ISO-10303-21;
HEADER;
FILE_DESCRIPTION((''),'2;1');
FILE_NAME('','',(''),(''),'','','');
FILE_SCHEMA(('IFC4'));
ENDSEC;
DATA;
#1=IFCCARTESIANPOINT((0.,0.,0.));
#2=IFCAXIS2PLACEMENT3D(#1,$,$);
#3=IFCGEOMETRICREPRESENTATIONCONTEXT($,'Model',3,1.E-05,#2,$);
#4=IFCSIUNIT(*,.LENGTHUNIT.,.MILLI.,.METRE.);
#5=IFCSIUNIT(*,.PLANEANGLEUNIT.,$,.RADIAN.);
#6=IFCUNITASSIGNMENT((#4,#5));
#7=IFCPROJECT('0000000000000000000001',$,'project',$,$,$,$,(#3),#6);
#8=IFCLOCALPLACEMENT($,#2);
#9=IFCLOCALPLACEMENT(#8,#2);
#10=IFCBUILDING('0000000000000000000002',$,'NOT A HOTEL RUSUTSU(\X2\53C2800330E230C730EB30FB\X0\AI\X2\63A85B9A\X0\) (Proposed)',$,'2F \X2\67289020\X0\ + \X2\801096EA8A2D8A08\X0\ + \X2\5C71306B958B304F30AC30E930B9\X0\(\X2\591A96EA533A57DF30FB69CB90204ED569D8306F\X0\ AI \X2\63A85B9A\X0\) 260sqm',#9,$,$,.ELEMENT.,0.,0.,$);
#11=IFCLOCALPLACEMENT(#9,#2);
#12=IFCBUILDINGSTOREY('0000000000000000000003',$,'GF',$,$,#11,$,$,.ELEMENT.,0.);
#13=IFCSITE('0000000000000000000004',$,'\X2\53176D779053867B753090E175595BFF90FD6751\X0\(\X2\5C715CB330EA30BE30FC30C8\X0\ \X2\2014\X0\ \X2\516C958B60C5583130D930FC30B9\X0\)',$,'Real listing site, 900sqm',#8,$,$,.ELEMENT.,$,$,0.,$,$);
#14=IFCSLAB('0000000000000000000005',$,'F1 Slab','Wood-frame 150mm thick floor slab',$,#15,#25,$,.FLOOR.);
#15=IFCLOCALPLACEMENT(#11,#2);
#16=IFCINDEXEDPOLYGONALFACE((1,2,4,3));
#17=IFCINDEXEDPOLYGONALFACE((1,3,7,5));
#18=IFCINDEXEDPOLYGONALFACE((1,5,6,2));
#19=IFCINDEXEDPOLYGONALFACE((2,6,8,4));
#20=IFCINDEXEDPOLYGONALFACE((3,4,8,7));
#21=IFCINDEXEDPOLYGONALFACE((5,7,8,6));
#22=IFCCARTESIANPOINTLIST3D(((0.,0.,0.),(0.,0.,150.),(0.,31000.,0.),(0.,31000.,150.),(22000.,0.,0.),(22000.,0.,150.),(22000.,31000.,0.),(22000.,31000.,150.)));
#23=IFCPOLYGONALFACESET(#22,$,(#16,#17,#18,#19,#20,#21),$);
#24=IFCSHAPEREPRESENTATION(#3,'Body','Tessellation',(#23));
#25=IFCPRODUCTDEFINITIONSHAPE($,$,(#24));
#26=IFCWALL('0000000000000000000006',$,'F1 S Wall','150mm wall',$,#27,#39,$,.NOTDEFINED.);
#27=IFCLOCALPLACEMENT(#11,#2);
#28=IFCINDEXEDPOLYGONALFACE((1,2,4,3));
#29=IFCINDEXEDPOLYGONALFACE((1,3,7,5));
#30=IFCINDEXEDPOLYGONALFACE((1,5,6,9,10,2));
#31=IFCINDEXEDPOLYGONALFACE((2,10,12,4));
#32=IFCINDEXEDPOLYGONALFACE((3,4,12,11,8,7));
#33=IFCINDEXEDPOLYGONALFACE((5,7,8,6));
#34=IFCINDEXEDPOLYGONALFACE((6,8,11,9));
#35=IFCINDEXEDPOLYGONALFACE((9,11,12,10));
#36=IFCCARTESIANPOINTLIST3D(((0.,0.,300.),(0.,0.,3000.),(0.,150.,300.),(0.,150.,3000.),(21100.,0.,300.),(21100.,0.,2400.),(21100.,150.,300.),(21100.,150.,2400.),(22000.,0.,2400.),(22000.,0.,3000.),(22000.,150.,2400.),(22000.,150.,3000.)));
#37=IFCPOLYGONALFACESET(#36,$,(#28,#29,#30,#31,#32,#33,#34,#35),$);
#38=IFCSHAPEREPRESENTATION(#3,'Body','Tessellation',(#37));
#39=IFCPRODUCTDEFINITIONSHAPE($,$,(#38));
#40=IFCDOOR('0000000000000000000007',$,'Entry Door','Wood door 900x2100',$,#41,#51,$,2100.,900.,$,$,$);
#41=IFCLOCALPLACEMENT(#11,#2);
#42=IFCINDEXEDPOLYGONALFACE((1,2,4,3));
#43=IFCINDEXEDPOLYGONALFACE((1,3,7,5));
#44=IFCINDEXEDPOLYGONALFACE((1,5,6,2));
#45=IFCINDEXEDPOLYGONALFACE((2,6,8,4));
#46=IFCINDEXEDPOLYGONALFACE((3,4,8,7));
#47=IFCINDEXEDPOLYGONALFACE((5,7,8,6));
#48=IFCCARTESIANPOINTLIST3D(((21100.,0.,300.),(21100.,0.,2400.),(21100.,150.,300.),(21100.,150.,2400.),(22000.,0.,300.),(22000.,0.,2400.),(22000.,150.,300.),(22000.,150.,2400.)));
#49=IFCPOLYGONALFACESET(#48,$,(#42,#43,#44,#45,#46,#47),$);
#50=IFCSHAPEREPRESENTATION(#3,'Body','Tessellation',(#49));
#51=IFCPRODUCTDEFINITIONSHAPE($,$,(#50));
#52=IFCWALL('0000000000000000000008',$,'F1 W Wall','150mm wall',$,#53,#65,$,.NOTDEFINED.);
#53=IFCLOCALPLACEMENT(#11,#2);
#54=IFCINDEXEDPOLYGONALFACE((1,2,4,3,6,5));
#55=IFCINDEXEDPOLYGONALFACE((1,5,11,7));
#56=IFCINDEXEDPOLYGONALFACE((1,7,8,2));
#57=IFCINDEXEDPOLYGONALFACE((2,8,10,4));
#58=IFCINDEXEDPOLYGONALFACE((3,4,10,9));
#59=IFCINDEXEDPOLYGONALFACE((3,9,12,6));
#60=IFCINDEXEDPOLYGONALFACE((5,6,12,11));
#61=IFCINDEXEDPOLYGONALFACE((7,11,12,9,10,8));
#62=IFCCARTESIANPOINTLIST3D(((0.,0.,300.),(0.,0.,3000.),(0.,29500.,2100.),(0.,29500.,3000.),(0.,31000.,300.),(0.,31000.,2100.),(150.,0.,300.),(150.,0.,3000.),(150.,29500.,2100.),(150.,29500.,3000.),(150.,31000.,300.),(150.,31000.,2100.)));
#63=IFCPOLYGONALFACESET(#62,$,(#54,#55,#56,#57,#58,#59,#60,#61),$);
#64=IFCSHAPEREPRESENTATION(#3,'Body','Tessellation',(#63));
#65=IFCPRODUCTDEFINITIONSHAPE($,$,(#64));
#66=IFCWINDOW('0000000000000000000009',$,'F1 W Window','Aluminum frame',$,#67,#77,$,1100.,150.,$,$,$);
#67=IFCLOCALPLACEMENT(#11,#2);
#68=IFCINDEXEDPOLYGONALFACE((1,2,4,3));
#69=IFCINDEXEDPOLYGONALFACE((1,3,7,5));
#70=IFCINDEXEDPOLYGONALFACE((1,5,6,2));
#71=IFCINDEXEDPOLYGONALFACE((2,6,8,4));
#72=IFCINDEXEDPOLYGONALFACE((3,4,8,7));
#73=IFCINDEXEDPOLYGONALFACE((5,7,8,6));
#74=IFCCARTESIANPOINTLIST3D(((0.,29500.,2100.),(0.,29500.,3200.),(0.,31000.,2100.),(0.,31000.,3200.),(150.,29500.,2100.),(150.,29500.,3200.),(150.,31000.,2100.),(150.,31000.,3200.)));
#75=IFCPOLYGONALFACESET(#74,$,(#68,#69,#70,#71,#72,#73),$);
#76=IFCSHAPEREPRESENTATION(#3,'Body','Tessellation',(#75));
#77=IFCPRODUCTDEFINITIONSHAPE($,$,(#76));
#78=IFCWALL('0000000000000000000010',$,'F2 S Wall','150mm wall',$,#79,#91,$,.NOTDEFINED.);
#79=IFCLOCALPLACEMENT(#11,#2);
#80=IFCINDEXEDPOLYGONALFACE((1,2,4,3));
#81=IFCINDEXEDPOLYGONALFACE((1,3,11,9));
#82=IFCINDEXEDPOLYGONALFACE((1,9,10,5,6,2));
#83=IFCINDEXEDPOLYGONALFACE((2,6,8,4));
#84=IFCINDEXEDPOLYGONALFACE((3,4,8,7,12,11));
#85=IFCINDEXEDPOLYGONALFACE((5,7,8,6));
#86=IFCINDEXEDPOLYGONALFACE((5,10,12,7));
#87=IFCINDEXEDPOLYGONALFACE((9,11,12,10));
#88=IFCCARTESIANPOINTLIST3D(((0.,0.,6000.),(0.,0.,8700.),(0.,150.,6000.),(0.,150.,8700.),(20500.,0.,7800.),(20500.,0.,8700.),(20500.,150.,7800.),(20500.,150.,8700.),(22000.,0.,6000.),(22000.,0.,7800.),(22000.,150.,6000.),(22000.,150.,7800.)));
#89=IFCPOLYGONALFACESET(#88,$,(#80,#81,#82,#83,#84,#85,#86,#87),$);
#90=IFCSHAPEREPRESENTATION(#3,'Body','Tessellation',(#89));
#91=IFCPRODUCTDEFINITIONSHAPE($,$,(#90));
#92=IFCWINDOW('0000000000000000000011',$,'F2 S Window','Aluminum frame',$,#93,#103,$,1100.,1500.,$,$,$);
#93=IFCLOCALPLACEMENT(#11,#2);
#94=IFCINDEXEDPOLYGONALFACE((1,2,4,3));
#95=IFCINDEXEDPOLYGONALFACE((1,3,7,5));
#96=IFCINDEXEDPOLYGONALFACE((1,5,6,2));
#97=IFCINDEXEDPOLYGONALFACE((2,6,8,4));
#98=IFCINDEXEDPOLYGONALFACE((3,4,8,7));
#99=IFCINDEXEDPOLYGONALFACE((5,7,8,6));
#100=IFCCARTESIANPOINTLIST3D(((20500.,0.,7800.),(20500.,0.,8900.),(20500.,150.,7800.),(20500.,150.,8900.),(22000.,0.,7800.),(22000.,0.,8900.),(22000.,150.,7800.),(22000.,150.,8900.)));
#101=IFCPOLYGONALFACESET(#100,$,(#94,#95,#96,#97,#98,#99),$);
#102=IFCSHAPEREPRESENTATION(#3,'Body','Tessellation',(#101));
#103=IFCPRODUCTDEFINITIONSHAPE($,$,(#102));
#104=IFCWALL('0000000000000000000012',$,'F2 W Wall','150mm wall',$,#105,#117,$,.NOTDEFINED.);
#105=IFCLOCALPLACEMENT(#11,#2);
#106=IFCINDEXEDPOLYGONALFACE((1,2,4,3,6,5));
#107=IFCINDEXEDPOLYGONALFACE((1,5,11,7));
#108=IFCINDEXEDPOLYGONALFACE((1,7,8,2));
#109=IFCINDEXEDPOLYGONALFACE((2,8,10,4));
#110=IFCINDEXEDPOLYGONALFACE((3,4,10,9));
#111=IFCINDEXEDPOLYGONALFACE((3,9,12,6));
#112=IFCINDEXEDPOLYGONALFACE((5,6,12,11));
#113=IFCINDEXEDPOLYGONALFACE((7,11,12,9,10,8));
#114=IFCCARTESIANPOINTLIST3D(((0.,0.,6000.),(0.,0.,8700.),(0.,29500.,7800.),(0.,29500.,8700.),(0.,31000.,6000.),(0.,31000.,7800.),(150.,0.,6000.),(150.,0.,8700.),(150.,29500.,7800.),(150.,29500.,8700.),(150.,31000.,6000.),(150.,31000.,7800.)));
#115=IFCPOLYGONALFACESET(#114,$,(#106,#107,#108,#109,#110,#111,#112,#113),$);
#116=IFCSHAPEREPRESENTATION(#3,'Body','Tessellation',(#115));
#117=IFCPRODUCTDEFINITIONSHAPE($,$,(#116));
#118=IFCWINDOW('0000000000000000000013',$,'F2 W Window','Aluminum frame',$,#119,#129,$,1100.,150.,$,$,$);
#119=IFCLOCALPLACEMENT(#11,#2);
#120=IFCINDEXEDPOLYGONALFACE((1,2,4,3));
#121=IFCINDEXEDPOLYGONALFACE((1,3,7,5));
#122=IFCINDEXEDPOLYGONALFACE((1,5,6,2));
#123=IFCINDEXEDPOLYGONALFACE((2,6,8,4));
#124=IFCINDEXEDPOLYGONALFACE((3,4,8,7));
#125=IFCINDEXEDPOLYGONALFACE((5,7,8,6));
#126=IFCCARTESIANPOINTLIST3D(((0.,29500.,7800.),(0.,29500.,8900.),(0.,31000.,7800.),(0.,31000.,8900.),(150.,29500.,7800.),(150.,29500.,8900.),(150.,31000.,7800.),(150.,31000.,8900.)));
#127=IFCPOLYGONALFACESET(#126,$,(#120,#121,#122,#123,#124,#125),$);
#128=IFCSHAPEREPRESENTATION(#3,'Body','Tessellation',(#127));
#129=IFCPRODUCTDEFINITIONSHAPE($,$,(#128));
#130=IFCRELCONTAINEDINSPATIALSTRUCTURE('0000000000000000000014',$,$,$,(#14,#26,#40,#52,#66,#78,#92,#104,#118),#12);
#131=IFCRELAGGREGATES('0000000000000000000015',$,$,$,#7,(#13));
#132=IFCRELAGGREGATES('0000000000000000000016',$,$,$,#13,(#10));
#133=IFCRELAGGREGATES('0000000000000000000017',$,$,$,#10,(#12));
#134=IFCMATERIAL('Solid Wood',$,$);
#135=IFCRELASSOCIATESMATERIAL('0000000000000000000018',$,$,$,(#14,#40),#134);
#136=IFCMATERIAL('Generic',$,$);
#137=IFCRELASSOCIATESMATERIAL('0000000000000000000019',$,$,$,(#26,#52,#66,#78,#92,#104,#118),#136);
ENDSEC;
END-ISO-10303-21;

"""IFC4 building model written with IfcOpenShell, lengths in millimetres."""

from ifc_helpers import new_model, si_unit, frame, frame_2d, origin, place, context, project, spatial, rectangle, extrude, material, element, fill, save


model = new_model("IFC4")

# Units and contexts
model_context = context("Model", 3, precision=1e-05, world=origin())
ifc_project = project(units=[si_unit("LENGTHUNIT", "METRE", prefix="MILLI"), si_unit("PLANEANGLEUNIT", "RADIAN")], contexts=[model_context])

# Site, building, storey
site_placement = place(None, origin())
site = spatial("IfcSite", under=ifc_project, at=site_placement, Name="北海道虻田郡留寿都村(山岳リゾート — 公開情報ベース)", ObjectType="Real listing site, 900sqm", CompositionType="ELEMENT", RefElevation=0.0)
building_placement = place(site_placement, origin())
building = spatial("IfcBuilding", under=site, at=building_placement, Name="NOT A HOTEL RUSUTSU(参考モデル・AI推定) (Proposed)", ObjectType="2F 木造 + 耐雪設計 + 山に開くガラス(多雪区域・構造仕様は AI 推定) 260sqm", CompositionType="ELEMENT", ElevationOfRefHeight=0.0, ElevationOfTerrain=0.0)
storey_placement = place(building_placement, origin())
storey = spatial("IfcBuildingStorey", under=building, at=storey_placement, Name="GF", CompositionType="ELEMENT", Elevation=0.0)

# Slab
ifc_material_1 = material(Name="Solid Wood")
slab_1_placement = place(storey_placement, origin())
element("IfcSlab", 1, at=slab_1_placement, inside=storey, material=ifc_material_1, Name="F1 Slab", Description="Wood-frame 150mm thick floor slab", PredefinedType="FLOOR", context=model_context, shape_type="SweptSolid", body=[
    extrude(rectangle(XDim=22000.0, YDim=31000.0, at=frame_2d((11000.0, 15500.0))), origin(), (0.0, 0.0, 1.0), 150.0),
])

# Shared definitions
ifc_material_2 = material(Name="Generic")

# Wall, opening, door
wall_1_placement = place(storey_placement, frame((0.0, 0.0, 150.0)))
wall_1 = element("IfcWall", 2, at=wall_1_placement, inside=storey, material=ifc_material_2, Name="F1 S Wall", Description="150mm wall", PredefinedType="NOTDEFINED", context=model_context, shape_type="SweptSolid", body=[
    extrude(rectangle(XDim=22000.0, YDim=150.0, at=frame_2d((11000.0, 75.0))), frame((0.0, 0.0, 150.0)), (0.0, 0.0, 1.0), 2700.0),
])
opening_1_placement = place(storey_placement, frame((10550.0, 0.0, 150.0)))
opening_1 = element("IfcOpeningElement", 3, at=opening_1_placement, cuts=wall_1, PredefinedType="NOTDEFINED", context=model_context, shape_type="SweptSolid", body=[
    extrude(rectangle(XDim=900.0, YDim=150.0, at=frame_2d((450.0, 75.0))), frame((10550.0, 0.0, 150.0)), (0.0, 0.0, 1.0), 2100.0),
])
door_placement = place(storey_placement, frame((10550.0, 0.0, 150.0)))
door = element("IfcDoor", 4, at=door_placement, inside=storey, material=ifc_material_1, Name="Entry Door", Description="Wood door 900x2100", OverallHeight=2100.0, OverallWidth=900.0, context=model_context, shape_type="SweptSolid", body=[
    extrude(rectangle(XDim=900.0, YDim=150.0, at=frame_2d((450.0, 75.0))), frame((10550.0, 0.0, 150.0)), (0.0, 0.0, 1.0), 2100.0),
])
fill(opening_1, door)

# Walls, openings, windows
wall_2_placement = place(storey_placement, frame((0.0, 0.0, 150.0)))
wall_2 = element("IfcWall", 5, at=wall_2_placement, inside=storey, material=ifc_material_2, Name="F1 W Wall", Description="150mm wall", PredefinedType="NOTDEFINED", context=model_context, shape_type="SweptSolid", body=[
    extrude(rectangle(XDim=150.0, YDim=31000.0, at=frame_2d((75.0, 15500.0))), frame((0.0, 0.0, 150.0)), (0.0, 0.0, 1.0), 2700.0),
])
opening_2_placement = place(storey_placement, frame((0.0, 14750.0, 1050.0)))
opening_2 = element("IfcOpeningElement", 6, at=opening_2_placement, cuts=wall_2, PredefinedType="NOTDEFINED", context=model_context, shape_type="SweptSolid", body=[
    extrude(rectangle(XDim=150.0, YDim=1500.0, at=frame_2d((75.0, 750.0))), frame((0.0, 14750.0, 1050.0)), (0.0, 0.0, 1.0), 1100.0),
])
window_1_placement = place(storey_placement, frame((0.0, 14750.0, 1050.0)))
window_1 = element("IfcWindow", 7, at=window_1_placement, inside=storey, material=ifc_material_2, Name="F1 W Window", Description="Aluminum frame", OverallHeight=1100.0, OverallWidth=150.0, context=model_context, shape_type="SweptSolid", body=[
    extrude(rectangle(XDim=150.0, YDim=1500.0, at=frame_2d((75.0, 750.0))), frame((0.0, 14750.0, 1050.0)), (0.0, 0.0, 1.0), 1100.0),
])
fill(opening_2, window_1)
wall_3_placement = place(storey_placement, frame((0.0, 0.0, 3000.0)))
wall_3 = element("IfcWall", 8, at=wall_3_placement, inside=storey, material=ifc_material_2, Name="F2 S Wall", Description="150mm wall", PredefinedType="NOTDEFINED", context=model_context, shape_type="SweptSolid", body=[
    extrude(rectangle(XDim=22000.0, YDim=150.0, at=frame_2d((11000.0, 75.0))), frame((0.0, 0.0, 3000.0)), (0.0, 0.0, 1.0), 2700.0),
])
opening_3_placement = place(storey_placement, frame((10250.0, 0.0, 3900.0)))
opening_3 = element("IfcOpeningElement", 9, at=opening_3_placement, cuts=wall_3, PredefinedType="NOTDEFINED", context=model_context, shape_type="SweptSolid", body=[
    extrude(rectangle(XDim=1500.0, YDim=150.0, at=frame_2d((750.0, 75.0))), frame((10250.0, 0.0, 3900.0)), (0.0, 0.0, 1.0), 1100.0),
])
window_2_placement = place(storey_placement, frame((10250.0, 0.0, 3900.0)))
window_2 = element("IfcWindow", 10, at=window_2_placement, inside=storey, material=ifc_material_2, Name="F2 S Window", Description="Aluminum frame", OverallHeight=1100.0, OverallWidth=1500.0, context=model_context, shape_type="SweptSolid", body=[
    extrude(rectangle(XDim=1500.0, YDim=150.0, at=frame_2d((750.0, 75.0))), frame((10250.0, 0.0, 3900.0)), (0.0, 0.0, 1.0), 1100.0),
])
fill(opening_3, window_2)
wall_4_placement = place(storey_placement, frame((0.0, 0.0, 3000.0)))
wall_4 = element("IfcWall", 11, at=wall_4_placement, inside=storey, material=ifc_material_2, Name="F2 W Wall", Description="150mm wall", PredefinedType="NOTDEFINED", context=model_context, shape_type="SweptSolid", body=[
    extrude(rectangle(XDim=150.0, YDim=31000.0, at=frame_2d((75.0, 15500.0))), frame((0.0, 0.0, 3000.0)), (0.0, 0.0, 1.0), 2700.0),
])
opening_4_placement = place(storey_placement, frame((0.0, 14750.0, 3900.0)))
opening_4 = element("IfcOpeningElement", 12, at=opening_4_placement, cuts=wall_4, PredefinedType="NOTDEFINED", context=model_context, shape_type="SweptSolid", body=[
    extrude(rectangle(XDim=150.0, YDim=1500.0, at=frame_2d((75.0, 750.0))), frame((0.0, 14750.0, 3900.0)), (0.0, 0.0, 1.0), 1100.0),
])
window_3_placement = place(storey_placement, frame((0.0, 14750.0, 3900.0)))
window_3 = element("IfcWindow", 13, at=window_3_placement, inside=storey, material=ifc_material_2, Name="F2 W Window", Description="Aluminum frame", OverallHeight=1100.0, OverallWidth=150.0, context=model_context, shape_type="SweptSolid", body=[
    extrude(rectangle(XDim=150.0, YDim=1500.0, at=frame_2d((75.0, 750.0))), frame((0.0, 14750.0, 3900.0)), (0.0, 0.0, 1.0), 1100.0),
])
fill(opening_4, window_3)

save(model, "model.ifc")
